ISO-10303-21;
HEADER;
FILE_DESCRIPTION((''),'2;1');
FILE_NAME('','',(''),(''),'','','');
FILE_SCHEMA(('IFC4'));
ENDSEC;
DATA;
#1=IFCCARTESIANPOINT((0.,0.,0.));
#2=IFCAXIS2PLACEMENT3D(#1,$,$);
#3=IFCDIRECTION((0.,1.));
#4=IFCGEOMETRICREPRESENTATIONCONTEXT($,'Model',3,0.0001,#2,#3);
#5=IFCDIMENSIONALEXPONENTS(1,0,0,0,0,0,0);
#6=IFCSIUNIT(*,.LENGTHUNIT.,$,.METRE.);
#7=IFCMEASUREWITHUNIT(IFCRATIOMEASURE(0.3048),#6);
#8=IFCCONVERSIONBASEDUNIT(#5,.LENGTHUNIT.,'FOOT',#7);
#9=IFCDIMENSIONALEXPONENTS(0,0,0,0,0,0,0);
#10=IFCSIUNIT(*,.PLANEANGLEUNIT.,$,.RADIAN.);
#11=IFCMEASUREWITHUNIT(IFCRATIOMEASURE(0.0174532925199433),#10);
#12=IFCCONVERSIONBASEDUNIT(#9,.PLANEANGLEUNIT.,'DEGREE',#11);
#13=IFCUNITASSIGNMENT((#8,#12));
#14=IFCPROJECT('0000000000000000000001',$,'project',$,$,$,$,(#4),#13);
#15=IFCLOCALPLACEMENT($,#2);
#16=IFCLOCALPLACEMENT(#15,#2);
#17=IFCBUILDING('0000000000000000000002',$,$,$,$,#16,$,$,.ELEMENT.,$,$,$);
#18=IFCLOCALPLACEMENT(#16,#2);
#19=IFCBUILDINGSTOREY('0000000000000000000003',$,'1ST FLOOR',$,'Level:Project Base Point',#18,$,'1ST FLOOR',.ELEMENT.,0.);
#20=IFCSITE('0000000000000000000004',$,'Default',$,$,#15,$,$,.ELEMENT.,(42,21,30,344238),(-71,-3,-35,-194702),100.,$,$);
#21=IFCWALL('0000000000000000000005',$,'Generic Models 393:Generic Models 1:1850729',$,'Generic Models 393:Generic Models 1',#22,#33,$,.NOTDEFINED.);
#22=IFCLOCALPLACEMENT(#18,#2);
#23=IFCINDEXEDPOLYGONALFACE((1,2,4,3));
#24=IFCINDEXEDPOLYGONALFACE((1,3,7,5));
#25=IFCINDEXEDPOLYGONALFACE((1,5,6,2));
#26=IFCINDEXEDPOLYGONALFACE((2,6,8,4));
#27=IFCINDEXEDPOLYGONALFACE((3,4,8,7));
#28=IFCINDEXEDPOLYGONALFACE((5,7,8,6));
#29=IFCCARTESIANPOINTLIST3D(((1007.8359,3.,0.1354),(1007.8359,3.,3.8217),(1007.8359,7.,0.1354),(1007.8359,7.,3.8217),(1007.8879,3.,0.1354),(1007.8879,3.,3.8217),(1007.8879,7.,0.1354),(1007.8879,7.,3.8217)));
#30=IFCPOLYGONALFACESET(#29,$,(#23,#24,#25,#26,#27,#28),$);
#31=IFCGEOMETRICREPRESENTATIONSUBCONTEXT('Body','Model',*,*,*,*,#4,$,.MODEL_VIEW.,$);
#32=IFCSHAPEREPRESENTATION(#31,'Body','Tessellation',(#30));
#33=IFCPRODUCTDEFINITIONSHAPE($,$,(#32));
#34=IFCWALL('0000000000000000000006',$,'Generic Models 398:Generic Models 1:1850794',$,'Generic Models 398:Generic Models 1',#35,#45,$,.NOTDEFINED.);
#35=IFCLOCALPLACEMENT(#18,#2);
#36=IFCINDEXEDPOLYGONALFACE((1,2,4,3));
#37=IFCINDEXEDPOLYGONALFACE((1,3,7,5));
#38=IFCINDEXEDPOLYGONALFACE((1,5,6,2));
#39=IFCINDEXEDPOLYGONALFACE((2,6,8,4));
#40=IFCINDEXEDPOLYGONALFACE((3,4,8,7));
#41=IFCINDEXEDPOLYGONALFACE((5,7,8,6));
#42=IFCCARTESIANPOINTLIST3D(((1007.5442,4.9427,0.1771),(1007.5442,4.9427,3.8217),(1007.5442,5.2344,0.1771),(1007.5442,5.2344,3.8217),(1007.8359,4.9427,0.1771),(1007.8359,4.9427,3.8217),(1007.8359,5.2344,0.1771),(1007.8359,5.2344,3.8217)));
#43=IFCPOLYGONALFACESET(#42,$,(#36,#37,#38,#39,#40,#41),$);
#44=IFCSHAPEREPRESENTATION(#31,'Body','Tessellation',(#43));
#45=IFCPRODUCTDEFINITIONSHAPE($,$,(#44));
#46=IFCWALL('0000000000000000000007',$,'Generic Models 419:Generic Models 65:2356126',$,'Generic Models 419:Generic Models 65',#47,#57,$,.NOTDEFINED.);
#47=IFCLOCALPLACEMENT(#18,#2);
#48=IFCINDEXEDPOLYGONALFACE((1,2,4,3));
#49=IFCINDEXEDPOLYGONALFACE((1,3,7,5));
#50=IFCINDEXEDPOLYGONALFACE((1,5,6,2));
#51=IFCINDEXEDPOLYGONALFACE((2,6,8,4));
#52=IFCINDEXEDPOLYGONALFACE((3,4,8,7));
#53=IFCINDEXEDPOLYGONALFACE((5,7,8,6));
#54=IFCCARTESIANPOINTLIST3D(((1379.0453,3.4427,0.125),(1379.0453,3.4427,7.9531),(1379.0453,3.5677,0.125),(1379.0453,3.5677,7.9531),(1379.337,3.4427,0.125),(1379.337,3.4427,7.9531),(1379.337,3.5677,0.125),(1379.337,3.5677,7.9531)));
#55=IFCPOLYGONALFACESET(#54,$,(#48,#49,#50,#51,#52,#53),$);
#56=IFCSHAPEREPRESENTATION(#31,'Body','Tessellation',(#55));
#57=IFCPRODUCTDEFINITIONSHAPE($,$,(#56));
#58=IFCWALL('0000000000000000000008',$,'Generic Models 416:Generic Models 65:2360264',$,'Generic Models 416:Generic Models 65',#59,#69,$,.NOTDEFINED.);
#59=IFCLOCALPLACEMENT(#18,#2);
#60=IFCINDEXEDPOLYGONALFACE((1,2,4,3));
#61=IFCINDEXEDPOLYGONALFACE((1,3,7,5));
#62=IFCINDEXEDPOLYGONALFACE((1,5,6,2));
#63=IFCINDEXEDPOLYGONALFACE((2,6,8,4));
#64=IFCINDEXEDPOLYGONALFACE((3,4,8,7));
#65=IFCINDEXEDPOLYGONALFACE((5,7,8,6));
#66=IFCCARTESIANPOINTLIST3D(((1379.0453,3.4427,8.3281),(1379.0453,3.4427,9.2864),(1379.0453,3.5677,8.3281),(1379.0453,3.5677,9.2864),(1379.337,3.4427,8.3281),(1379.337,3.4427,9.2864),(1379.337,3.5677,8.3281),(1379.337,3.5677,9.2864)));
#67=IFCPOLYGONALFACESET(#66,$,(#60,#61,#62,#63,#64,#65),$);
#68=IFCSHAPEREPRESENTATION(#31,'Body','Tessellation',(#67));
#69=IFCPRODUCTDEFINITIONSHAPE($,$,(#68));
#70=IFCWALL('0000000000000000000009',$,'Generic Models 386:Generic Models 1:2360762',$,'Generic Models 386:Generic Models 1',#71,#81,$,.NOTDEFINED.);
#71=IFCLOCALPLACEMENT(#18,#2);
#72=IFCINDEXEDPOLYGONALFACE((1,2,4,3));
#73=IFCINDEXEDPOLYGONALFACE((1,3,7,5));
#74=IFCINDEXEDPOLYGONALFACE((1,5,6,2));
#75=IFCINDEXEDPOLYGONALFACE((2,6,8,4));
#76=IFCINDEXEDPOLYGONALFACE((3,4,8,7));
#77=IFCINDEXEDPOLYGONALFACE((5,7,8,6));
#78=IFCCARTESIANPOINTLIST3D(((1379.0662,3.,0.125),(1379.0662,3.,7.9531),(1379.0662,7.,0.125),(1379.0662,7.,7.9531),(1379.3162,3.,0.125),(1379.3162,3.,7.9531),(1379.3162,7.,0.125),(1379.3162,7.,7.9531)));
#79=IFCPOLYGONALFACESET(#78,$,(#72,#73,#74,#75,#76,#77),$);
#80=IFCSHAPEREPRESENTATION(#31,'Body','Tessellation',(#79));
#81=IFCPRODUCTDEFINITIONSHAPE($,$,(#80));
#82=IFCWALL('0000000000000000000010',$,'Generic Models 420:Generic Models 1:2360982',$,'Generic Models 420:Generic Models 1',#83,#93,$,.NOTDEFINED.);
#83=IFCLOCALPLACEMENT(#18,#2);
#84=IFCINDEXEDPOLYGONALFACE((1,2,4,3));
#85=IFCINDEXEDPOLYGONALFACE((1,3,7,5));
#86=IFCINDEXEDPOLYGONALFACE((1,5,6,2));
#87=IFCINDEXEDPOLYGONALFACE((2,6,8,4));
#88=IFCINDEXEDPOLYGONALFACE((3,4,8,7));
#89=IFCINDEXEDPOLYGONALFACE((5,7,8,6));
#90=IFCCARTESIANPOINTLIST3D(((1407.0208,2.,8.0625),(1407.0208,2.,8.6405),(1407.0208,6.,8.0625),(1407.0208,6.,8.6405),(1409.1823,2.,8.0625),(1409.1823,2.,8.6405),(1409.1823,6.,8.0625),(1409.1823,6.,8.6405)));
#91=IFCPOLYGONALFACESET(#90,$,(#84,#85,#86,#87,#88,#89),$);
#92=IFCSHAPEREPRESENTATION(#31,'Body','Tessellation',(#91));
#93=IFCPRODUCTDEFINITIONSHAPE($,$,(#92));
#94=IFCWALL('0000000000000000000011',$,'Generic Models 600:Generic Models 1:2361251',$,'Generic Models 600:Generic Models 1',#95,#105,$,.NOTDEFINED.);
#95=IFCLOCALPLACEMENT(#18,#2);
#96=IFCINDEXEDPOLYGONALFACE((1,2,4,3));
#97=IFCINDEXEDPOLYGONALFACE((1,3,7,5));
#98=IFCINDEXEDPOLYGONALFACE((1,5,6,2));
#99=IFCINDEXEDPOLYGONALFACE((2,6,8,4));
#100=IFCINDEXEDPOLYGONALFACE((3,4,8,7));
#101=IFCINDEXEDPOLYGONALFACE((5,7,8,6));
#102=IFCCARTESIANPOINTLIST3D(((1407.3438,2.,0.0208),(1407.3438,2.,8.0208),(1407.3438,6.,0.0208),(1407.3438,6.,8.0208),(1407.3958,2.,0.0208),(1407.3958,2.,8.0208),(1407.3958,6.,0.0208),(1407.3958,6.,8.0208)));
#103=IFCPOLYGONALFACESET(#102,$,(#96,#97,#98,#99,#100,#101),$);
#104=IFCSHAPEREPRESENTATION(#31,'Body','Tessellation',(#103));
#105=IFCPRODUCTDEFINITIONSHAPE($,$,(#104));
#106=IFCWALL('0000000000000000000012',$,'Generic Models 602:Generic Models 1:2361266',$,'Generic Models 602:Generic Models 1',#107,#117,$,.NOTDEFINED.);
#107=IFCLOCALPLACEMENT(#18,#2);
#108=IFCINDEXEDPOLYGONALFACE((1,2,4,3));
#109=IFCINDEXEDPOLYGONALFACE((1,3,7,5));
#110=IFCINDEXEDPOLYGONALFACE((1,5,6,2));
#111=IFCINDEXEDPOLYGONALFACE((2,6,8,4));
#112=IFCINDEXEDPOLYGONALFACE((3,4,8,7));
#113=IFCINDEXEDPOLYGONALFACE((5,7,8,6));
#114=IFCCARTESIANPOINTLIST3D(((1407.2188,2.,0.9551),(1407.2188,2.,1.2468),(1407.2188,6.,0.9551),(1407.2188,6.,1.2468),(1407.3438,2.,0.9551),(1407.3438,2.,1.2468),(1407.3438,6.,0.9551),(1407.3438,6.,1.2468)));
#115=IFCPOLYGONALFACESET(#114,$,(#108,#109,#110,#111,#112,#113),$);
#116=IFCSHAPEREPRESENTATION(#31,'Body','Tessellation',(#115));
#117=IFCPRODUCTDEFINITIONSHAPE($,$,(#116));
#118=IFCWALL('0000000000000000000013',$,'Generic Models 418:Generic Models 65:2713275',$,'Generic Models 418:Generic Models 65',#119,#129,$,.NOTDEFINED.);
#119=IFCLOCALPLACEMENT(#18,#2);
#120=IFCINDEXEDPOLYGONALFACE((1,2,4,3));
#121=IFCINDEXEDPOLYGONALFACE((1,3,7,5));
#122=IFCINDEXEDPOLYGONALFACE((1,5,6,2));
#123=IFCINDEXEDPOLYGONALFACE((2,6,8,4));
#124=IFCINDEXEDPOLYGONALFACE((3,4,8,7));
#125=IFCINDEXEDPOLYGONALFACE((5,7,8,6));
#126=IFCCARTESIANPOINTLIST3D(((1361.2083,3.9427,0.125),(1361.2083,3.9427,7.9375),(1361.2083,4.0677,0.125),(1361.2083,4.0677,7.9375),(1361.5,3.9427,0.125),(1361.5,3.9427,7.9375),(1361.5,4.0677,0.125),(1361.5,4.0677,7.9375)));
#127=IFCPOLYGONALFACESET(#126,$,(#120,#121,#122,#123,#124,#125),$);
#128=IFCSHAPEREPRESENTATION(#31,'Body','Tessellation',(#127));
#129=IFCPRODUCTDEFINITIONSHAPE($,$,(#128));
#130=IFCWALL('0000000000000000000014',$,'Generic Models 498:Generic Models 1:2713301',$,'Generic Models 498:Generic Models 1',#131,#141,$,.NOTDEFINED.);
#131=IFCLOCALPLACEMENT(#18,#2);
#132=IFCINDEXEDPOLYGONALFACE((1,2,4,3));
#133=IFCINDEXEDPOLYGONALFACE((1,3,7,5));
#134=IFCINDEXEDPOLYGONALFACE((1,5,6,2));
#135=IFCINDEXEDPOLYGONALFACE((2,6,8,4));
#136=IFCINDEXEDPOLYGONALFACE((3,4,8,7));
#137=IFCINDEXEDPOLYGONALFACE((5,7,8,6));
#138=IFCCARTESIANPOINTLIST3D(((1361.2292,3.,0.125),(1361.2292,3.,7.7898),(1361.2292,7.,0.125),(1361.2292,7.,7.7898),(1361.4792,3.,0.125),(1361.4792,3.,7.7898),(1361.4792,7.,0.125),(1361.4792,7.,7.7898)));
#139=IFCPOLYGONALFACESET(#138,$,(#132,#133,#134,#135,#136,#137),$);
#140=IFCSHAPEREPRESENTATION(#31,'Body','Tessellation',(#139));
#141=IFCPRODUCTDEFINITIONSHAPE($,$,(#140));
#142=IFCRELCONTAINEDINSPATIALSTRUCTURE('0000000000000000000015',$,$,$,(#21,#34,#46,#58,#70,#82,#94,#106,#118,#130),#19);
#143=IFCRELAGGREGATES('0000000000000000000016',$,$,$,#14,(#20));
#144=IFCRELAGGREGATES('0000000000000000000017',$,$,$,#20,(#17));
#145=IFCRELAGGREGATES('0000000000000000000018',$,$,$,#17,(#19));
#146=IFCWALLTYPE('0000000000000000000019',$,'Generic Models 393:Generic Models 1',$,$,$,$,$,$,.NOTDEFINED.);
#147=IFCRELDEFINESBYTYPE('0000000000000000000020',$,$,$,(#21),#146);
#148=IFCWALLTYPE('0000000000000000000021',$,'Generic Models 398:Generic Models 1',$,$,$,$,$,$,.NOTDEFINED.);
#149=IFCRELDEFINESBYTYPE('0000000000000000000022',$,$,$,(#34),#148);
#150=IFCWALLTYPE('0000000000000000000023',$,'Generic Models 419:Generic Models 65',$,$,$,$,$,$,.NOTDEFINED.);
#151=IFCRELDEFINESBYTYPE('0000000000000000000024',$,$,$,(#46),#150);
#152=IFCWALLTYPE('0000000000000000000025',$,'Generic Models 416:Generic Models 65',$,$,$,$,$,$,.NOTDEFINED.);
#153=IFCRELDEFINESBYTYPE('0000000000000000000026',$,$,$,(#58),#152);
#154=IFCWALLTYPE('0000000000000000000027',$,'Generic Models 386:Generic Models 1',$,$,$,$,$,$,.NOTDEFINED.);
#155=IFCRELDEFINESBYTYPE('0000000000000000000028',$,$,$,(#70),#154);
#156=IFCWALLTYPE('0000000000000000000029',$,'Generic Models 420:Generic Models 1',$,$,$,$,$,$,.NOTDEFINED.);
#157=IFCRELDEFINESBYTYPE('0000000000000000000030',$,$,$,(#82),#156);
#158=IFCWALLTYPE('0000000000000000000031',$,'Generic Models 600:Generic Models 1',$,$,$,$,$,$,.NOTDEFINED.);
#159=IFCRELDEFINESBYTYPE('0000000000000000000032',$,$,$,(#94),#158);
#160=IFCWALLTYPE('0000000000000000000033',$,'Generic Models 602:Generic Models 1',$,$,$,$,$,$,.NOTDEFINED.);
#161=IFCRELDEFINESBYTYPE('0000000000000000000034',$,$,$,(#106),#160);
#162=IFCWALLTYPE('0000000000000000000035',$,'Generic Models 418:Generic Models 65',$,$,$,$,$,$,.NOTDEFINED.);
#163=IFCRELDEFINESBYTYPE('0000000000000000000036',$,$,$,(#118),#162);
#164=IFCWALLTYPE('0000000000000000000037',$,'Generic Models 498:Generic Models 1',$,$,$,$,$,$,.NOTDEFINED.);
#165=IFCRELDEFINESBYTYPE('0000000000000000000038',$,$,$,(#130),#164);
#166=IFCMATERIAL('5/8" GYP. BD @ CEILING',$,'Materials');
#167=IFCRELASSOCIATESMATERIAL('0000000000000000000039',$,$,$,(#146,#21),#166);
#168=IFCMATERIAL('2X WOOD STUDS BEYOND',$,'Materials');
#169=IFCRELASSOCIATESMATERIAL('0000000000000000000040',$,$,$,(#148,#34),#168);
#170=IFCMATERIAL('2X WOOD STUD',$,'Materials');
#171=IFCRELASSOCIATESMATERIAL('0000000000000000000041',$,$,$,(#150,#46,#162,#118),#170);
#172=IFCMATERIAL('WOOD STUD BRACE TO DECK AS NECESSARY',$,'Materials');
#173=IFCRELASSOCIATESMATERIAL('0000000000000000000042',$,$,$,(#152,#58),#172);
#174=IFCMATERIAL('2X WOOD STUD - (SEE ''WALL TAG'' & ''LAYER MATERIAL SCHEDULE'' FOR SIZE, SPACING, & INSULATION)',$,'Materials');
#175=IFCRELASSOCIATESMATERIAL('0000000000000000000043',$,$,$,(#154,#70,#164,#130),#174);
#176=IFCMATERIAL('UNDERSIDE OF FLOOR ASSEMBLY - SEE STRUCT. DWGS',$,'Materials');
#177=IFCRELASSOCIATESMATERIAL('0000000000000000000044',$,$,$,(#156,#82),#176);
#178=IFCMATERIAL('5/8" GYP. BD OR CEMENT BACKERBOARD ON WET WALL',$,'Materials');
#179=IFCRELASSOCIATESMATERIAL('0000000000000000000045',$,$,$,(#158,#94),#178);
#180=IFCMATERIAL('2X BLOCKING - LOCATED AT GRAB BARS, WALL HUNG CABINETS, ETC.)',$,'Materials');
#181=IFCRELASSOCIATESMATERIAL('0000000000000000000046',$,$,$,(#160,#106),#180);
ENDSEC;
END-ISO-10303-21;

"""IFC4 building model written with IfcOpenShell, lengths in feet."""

from ifc_helpers import new_model, entity, si_unit, converted_unit, direction, frame, frame_2d, origin, origin_2d_with_axis, place, context, subcontext, project, spatial, rectangle, extrude, material, type_object, element, save


model = new_model("IFC4")

# Units and contexts
model_context = context("Model", 3, precision=0.0001, world=origin(), true_north=direction((0.0, 1.0)))
body_context = subcontext(model_context, "Body", "Model", "MODEL_VIEW")
ifc_project = project(units=[converted_unit("LENGTHUNIT", "FOOT", entity("IfcRatioMeasure", 0.3048), si_unit("LENGTHUNIT", "METRE"), dimensions=[1, 0, 0, 0, 0, 0, 0]), converted_unit("PLANEANGLEUNIT", "DEGREE", entity("IfcRatioMeasure", 0.0174532925199433), si_unit("PLANEANGLEUNIT", "RADIAN"), dimensions=[0, 0, 0, 0, 0, 0, 0])], contexts=[model_context])

# Site, building, storey
site_placement = place(None, origin())
site = spatial("IfcSite", under=ifc_project, at=site_placement, Name="Default", CompositionType="ELEMENT", RefLatitude=(42, 21, 30, 344238), RefLongitude=(-71, -3, -35, -194702), RefElevation=100.0)
building_placement = place(site_placement, origin())
building = spatial("IfcBuilding", under=site, at=building_placement, CompositionType="ELEMENT")
storey_placement = place(building_placement, origin())
storey = spatial("IfcBuildingStorey", under=building, at=storey_placement, Name="1ST FLOOR", ObjectType="Level:Project Base Point", LongName="1ST FLOOR", CompositionType="ELEMENT", Elevation=0.0)

# Walls
ifc_material_1 = material(Name="2X WOOD STUD", Category="Materials")
ifc_material_2 = material(Name="2X WOOD STUD - (SEE 'WALL TAG' & 'LAYER MATERIAL SCHEDULE' FOR SIZE, SPACING, & INSULATION)", Category="Materials")
ifc_material_3 = material(Name="5/8\" GYP. BD @ CEILING", Category="Materials")
wall_type_1 = type_object("IfcWallType", Name="Generic Models 393:Generic Models 1", PredefinedType="NOTDEFINED", material=ifc_material_3)
wall_1_placement = place(storey_placement, frame((1007.8359, 3.0, 0.1354), z_axis=(0.0, 0.0, 1.0), x_axis=(0.0, 1.0, 0.0)))
element("IfcWall", 1, at=wall_1_placement, inside=storey, type_object=wall_type_1, material=ifc_material_3, Name="Generic Models 393:Generic Models 1:1850729", ObjectType="Generic Models 393:Generic Models 1", PredefinedType="NOTDEFINED", context=body_context, shape_type="SweptSolid", body=[
    extrude(rectangle(XDim=4.0, YDim=0.0521, at=frame_2d((0.0, 0.0), x_axis=(1.0, 0.0))), frame((2.0, -0.026, 0.0)), (0.0, 0.0, 1.0), 3.6863),
])
ifc_material_4 = material(Name="2X WOOD STUDS BEYOND", Category="Materials")
wall_type_2 = type_object("IfcWallType", Name="Generic Models 398:Generic Models 1", PredefinedType="NOTDEFINED", material=ifc_material_4)
wall_2_placement = place(storey_placement, frame((1007.5442, 4.9427, 0.1771)))
element("IfcWall", 2, at=wall_2_placement, inside=storey, type_object=wall_type_2, material=ifc_material_4, Name="Generic Models 398:Generic Models 1:1850794", ObjectType="Generic Models 398:Generic Models 1", PredefinedType="NOTDEFINED", context=body_context, shape_type="SweptSolid", body=[
    extrude(rectangle(XDim=0.2917, YDim=0.2917, at=origin_2d_with_axis()), frame((0.1458, 0.1458, 0.0), z_axis=(0.0, 0.0, 1.0), x_axis=(0.0, 1.0, 0.0)), (0.0, 0.0, 1.0), 3.6447),
])
wall_type_3 = type_object("IfcWallType", Name="Generic Models 419:Generic Models 65", PredefinedType="NOTDEFINED", material=ifc_material_1)
wall_3_placement = place(storey_placement, frame((1379.0453, 3.4427, 0.125)))
element("IfcWall", 3, at=wall_3_placement, inside=storey, type_object=wall_type_3, material=ifc_material_1, Name="Generic Models 419:Generic Models 65:2356126", ObjectType="Generic Models 419:Generic Models 65", PredefinedType="NOTDEFINED", context=body_context, shape_type="SweptSolid", body=[
    extrude(rectangle(XDim=0.125, YDim=0.2917, at=frame_2d((0.0, 0.0), x_axis=(1.0, 0.0))), frame((0.1458, 0.0625, 0.0), z_axis=(0.0, 0.0, 1.0), x_axis=(0.0, 1.0, 0.0)), (0.0, 0.0, 1.0), 7.8281),
])
ifc_material_5 = material(Name="WOOD STUD BRACE TO DECK AS NECESSARY", Category="Materials")
wall_type_4 = type_object("IfcWallType", Name="Generic Models 416:Generic Models 65", PredefinedType="NOTDEFINED", material=ifc_material_5)
wall_4_placement = place(storey_placement, frame((1379.0453, 3.4427, 8.3281)))
element("IfcWall", 4, at=wall_4_placement, inside=storey, type_object=wall_type_4, material=ifc_material_5, Name="Generic Models 416:Generic Models 65:2360264", ObjectType="Generic Models 416:Generic Models 65", PredefinedType="NOTDEFINED", context=body_context, shape_type="SweptSolid", body=[
    extrude(rectangle(XDim=0.125, YDim=0.2917, at=frame_2d((0.0, 0.0), x_axis=(1.0, 0.0))), frame((0.1458, 0.0625, 0.0), z_axis=(0.0, 0.0, 1.0), x_axis=(0.0, 1.0, 0.0)), (0.0, 0.0, 1.0), 0.9583),
])
wall_type_5 = type_object("IfcWallType", Name="Generic Models 386:Generic Models 1", PredefinedType="NOTDEFINED", material=ifc_material_2)
wall_5_placement = place(storey_placement, frame((1379.0662, 3.0, 0.125), z_axis=(0.0, 0.0, 1.0), x_axis=(0.0, 1.0, 0.0)))
element("IfcWall", 5, at=wall_5_placement, inside=storey, type_object=wall_type_5, material=ifc_material_2, Name="Generic Models 386:Generic Models 1:2360762", ObjectType="Generic Models 386:Generic Models 1", PredefinedType="NOTDEFINED", context=body_context, shape_type="SweptSolid", body=[
    extrude(rectangle(XDim=4.0, YDim=0.25, at=frame_2d((0.0, 0.0), x_axis=(1.0, 0.0))), frame((2.0, -0.125, 0.0)), (0.0, 0.0, 1.0), 7.8281),
])
ifc_material_6 = material(Name="UNDERSIDE OF FLOOR ASSEMBLY - SEE STRUCT. DWGS", Category="Materials")
wall_type_6 = type_object("IfcWallType", Name="Generic Models 420:Generic Models 1", PredefinedType="NOTDEFINED", material=ifc_material_6)
wall_6_placement = place(storey_placement, frame((1407.0208, 2.0, 8.0625), z_axis=(0.0, 0.0, 1.0), x_axis=(0.0, 1.0, 0.0)))
element("IfcWall", 6, at=wall_6_placement, inside=storey, type_object=wall_type_6, material=ifc_material_6, Name="Generic Models 420:Generic Models 1:2360982", ObjectType="Generic Models 420:Generic Models 1", PredefinedType="NOTDEFINED", context=body_context, shape_type="SweptSolid", body=[
    extrude(rectangle(XDim=4.0, YDim=2.1615, at=frame_2d((0.0, 0.0), x_axis=(1.0, 0.0))), frame((2.0, -1.0807, 0.0)), (0.0, 0.0, 1.0), 0.578),
])
ifc_material_7 = material(Name="5/8\" GYP. BD OR CEMENT BACKERBOARD ON WET WALL", Category="Materials")
wall_type_7 = type_object("IfcWallType", Name="Generic Models 600:Generic Models 1", PredefinedType="NOTDEFINED", material=ifc_material_7)
wall_7_placement = place(storey_placement, frame((1407.3438, 2.0, 0.0208), z_axis=(0.0, 0.0, 1.0), x_axis=(0.0, 1.0, 0.0)))
element("IfcWall", 7, at=wall_7_placement, inside=storey, type_object=wall_type_7, material=ifc_material_7, Name="Generic Models 600:Generic Models 1:2361251", ObjectType="Generic Models 600:Generic Models 1", PredefinedType="NOTDEFINED", context=body_context, shape_type="SweptSolid", body=[
    extrude(rectangle(XDim=4.0, YDim=0.0521, at=frame_2d((0.0, 0.0), x_axis=(1.0, 0.0))), frame((2.0, -0.026, 0.0)), (0.0, 0.0, 1.0), 8.0),
])
ifc_material_8 = material(Name="2X BLOCKING - LOCATED AT GRAB BARS, WALL HUNG CABINETS, ETC.)", Category="Materials")
wall_type_8 = type_object("IfcWallType", Name="Generic Models 602:Generic Models 1", PredefinedType="NOTDEFINED", material=ifc_material_8)
wall_8_placement = place(storey_placement, frame((1407.2188, 2.0, 0.9551), z_axis=(0.0, 0.0, 1.0), x_axis=(0.0, 1.0, 0.0)))
element("IfcWall", 8, at=wall_8_placement, inside=storey, type_object=wall_type_8, material=ifc_material_8, Name="Generic Models 602:Generic Models 1:2361266", ObjectType="Generic Models 602:Generic Models 1", PredefinedType="NOTDEFINED", context=body_context, shape_type="SweptSolid", body=[
    extrude(rectangle(XDim=4.0, YDim=0.125, at=frame_2d((0.0, 0.0), x_axis=(1.0, 0.0))), frame((2.0, -0.0625, 0.0)), (0.0, 0.0, 1.0), 0.2917),
])
wall_type_9 = type_object("IfcWallType", Name="Generic Models 418:Generic Models 65", PredefinedType="NOTDEFINED", material=ifc_material_1)
wall_9_placement = place(storey_placement, frame((1361.2083, 3.9427, 0.125)))
element("IfcWall", 9, at=wall_9_placement, inside=storey, type_object=wall_type_9, material=ifc_material_1, Name="Generic Models 418:Generic Models 65:2713275", ObjectType="Generic Models 418:Generic Models 65", PredefinedType="NOTDEFINED", context=body_context, shape_type="SweptSolid", body=[
    extrude(rectangle(XDim=0.125, YDim=0.2917, at=frame_2d((0.0, 0.0), x_axis=(1.0, 0.0))), frame((0.1458, 0.0625, 0.0), z_axis=(0.0, 0.0, 1.0), x_axis=(0.0, 1.0, 0.0)), (0.0, 0.0, 1.0), 7.8125),
])
wall_type_10 = type_object("IfcWallType", Name="Generic Models 498:Generic Models 1", PredefinedType="NOTDEFINED", material=ifc_material_2)
wall_10_placement = place(storey_placement, frame((1361.2292, 3.0, 0.125), z_axis=(0.0, 0.0, 1.0), x_axis=(0.0, 1.0, 0.0)))
element("IfcWall", 10, at=wall_10_placement, inside=storey, type_object=wall_type_10, material=ifc_material_2, Name="Generic Models 498:Generic Models 1:2713301", ObjectType="Generic Models 498:Generic Models 1", PredefinedType="NOTDEFINED", context=body_context, shape_type="SweptSolid", body=[
    extrude(rectangle(XDim=4.0, YDim=0.25, at=frame_2d((0.0, 0.0), x_axis=(1.0, 0.0))), frame((2.0, -0.125, 0.0)), (0.0, 0.0, 1.0), 7.6648),
])

save(model, "model.ifc")
